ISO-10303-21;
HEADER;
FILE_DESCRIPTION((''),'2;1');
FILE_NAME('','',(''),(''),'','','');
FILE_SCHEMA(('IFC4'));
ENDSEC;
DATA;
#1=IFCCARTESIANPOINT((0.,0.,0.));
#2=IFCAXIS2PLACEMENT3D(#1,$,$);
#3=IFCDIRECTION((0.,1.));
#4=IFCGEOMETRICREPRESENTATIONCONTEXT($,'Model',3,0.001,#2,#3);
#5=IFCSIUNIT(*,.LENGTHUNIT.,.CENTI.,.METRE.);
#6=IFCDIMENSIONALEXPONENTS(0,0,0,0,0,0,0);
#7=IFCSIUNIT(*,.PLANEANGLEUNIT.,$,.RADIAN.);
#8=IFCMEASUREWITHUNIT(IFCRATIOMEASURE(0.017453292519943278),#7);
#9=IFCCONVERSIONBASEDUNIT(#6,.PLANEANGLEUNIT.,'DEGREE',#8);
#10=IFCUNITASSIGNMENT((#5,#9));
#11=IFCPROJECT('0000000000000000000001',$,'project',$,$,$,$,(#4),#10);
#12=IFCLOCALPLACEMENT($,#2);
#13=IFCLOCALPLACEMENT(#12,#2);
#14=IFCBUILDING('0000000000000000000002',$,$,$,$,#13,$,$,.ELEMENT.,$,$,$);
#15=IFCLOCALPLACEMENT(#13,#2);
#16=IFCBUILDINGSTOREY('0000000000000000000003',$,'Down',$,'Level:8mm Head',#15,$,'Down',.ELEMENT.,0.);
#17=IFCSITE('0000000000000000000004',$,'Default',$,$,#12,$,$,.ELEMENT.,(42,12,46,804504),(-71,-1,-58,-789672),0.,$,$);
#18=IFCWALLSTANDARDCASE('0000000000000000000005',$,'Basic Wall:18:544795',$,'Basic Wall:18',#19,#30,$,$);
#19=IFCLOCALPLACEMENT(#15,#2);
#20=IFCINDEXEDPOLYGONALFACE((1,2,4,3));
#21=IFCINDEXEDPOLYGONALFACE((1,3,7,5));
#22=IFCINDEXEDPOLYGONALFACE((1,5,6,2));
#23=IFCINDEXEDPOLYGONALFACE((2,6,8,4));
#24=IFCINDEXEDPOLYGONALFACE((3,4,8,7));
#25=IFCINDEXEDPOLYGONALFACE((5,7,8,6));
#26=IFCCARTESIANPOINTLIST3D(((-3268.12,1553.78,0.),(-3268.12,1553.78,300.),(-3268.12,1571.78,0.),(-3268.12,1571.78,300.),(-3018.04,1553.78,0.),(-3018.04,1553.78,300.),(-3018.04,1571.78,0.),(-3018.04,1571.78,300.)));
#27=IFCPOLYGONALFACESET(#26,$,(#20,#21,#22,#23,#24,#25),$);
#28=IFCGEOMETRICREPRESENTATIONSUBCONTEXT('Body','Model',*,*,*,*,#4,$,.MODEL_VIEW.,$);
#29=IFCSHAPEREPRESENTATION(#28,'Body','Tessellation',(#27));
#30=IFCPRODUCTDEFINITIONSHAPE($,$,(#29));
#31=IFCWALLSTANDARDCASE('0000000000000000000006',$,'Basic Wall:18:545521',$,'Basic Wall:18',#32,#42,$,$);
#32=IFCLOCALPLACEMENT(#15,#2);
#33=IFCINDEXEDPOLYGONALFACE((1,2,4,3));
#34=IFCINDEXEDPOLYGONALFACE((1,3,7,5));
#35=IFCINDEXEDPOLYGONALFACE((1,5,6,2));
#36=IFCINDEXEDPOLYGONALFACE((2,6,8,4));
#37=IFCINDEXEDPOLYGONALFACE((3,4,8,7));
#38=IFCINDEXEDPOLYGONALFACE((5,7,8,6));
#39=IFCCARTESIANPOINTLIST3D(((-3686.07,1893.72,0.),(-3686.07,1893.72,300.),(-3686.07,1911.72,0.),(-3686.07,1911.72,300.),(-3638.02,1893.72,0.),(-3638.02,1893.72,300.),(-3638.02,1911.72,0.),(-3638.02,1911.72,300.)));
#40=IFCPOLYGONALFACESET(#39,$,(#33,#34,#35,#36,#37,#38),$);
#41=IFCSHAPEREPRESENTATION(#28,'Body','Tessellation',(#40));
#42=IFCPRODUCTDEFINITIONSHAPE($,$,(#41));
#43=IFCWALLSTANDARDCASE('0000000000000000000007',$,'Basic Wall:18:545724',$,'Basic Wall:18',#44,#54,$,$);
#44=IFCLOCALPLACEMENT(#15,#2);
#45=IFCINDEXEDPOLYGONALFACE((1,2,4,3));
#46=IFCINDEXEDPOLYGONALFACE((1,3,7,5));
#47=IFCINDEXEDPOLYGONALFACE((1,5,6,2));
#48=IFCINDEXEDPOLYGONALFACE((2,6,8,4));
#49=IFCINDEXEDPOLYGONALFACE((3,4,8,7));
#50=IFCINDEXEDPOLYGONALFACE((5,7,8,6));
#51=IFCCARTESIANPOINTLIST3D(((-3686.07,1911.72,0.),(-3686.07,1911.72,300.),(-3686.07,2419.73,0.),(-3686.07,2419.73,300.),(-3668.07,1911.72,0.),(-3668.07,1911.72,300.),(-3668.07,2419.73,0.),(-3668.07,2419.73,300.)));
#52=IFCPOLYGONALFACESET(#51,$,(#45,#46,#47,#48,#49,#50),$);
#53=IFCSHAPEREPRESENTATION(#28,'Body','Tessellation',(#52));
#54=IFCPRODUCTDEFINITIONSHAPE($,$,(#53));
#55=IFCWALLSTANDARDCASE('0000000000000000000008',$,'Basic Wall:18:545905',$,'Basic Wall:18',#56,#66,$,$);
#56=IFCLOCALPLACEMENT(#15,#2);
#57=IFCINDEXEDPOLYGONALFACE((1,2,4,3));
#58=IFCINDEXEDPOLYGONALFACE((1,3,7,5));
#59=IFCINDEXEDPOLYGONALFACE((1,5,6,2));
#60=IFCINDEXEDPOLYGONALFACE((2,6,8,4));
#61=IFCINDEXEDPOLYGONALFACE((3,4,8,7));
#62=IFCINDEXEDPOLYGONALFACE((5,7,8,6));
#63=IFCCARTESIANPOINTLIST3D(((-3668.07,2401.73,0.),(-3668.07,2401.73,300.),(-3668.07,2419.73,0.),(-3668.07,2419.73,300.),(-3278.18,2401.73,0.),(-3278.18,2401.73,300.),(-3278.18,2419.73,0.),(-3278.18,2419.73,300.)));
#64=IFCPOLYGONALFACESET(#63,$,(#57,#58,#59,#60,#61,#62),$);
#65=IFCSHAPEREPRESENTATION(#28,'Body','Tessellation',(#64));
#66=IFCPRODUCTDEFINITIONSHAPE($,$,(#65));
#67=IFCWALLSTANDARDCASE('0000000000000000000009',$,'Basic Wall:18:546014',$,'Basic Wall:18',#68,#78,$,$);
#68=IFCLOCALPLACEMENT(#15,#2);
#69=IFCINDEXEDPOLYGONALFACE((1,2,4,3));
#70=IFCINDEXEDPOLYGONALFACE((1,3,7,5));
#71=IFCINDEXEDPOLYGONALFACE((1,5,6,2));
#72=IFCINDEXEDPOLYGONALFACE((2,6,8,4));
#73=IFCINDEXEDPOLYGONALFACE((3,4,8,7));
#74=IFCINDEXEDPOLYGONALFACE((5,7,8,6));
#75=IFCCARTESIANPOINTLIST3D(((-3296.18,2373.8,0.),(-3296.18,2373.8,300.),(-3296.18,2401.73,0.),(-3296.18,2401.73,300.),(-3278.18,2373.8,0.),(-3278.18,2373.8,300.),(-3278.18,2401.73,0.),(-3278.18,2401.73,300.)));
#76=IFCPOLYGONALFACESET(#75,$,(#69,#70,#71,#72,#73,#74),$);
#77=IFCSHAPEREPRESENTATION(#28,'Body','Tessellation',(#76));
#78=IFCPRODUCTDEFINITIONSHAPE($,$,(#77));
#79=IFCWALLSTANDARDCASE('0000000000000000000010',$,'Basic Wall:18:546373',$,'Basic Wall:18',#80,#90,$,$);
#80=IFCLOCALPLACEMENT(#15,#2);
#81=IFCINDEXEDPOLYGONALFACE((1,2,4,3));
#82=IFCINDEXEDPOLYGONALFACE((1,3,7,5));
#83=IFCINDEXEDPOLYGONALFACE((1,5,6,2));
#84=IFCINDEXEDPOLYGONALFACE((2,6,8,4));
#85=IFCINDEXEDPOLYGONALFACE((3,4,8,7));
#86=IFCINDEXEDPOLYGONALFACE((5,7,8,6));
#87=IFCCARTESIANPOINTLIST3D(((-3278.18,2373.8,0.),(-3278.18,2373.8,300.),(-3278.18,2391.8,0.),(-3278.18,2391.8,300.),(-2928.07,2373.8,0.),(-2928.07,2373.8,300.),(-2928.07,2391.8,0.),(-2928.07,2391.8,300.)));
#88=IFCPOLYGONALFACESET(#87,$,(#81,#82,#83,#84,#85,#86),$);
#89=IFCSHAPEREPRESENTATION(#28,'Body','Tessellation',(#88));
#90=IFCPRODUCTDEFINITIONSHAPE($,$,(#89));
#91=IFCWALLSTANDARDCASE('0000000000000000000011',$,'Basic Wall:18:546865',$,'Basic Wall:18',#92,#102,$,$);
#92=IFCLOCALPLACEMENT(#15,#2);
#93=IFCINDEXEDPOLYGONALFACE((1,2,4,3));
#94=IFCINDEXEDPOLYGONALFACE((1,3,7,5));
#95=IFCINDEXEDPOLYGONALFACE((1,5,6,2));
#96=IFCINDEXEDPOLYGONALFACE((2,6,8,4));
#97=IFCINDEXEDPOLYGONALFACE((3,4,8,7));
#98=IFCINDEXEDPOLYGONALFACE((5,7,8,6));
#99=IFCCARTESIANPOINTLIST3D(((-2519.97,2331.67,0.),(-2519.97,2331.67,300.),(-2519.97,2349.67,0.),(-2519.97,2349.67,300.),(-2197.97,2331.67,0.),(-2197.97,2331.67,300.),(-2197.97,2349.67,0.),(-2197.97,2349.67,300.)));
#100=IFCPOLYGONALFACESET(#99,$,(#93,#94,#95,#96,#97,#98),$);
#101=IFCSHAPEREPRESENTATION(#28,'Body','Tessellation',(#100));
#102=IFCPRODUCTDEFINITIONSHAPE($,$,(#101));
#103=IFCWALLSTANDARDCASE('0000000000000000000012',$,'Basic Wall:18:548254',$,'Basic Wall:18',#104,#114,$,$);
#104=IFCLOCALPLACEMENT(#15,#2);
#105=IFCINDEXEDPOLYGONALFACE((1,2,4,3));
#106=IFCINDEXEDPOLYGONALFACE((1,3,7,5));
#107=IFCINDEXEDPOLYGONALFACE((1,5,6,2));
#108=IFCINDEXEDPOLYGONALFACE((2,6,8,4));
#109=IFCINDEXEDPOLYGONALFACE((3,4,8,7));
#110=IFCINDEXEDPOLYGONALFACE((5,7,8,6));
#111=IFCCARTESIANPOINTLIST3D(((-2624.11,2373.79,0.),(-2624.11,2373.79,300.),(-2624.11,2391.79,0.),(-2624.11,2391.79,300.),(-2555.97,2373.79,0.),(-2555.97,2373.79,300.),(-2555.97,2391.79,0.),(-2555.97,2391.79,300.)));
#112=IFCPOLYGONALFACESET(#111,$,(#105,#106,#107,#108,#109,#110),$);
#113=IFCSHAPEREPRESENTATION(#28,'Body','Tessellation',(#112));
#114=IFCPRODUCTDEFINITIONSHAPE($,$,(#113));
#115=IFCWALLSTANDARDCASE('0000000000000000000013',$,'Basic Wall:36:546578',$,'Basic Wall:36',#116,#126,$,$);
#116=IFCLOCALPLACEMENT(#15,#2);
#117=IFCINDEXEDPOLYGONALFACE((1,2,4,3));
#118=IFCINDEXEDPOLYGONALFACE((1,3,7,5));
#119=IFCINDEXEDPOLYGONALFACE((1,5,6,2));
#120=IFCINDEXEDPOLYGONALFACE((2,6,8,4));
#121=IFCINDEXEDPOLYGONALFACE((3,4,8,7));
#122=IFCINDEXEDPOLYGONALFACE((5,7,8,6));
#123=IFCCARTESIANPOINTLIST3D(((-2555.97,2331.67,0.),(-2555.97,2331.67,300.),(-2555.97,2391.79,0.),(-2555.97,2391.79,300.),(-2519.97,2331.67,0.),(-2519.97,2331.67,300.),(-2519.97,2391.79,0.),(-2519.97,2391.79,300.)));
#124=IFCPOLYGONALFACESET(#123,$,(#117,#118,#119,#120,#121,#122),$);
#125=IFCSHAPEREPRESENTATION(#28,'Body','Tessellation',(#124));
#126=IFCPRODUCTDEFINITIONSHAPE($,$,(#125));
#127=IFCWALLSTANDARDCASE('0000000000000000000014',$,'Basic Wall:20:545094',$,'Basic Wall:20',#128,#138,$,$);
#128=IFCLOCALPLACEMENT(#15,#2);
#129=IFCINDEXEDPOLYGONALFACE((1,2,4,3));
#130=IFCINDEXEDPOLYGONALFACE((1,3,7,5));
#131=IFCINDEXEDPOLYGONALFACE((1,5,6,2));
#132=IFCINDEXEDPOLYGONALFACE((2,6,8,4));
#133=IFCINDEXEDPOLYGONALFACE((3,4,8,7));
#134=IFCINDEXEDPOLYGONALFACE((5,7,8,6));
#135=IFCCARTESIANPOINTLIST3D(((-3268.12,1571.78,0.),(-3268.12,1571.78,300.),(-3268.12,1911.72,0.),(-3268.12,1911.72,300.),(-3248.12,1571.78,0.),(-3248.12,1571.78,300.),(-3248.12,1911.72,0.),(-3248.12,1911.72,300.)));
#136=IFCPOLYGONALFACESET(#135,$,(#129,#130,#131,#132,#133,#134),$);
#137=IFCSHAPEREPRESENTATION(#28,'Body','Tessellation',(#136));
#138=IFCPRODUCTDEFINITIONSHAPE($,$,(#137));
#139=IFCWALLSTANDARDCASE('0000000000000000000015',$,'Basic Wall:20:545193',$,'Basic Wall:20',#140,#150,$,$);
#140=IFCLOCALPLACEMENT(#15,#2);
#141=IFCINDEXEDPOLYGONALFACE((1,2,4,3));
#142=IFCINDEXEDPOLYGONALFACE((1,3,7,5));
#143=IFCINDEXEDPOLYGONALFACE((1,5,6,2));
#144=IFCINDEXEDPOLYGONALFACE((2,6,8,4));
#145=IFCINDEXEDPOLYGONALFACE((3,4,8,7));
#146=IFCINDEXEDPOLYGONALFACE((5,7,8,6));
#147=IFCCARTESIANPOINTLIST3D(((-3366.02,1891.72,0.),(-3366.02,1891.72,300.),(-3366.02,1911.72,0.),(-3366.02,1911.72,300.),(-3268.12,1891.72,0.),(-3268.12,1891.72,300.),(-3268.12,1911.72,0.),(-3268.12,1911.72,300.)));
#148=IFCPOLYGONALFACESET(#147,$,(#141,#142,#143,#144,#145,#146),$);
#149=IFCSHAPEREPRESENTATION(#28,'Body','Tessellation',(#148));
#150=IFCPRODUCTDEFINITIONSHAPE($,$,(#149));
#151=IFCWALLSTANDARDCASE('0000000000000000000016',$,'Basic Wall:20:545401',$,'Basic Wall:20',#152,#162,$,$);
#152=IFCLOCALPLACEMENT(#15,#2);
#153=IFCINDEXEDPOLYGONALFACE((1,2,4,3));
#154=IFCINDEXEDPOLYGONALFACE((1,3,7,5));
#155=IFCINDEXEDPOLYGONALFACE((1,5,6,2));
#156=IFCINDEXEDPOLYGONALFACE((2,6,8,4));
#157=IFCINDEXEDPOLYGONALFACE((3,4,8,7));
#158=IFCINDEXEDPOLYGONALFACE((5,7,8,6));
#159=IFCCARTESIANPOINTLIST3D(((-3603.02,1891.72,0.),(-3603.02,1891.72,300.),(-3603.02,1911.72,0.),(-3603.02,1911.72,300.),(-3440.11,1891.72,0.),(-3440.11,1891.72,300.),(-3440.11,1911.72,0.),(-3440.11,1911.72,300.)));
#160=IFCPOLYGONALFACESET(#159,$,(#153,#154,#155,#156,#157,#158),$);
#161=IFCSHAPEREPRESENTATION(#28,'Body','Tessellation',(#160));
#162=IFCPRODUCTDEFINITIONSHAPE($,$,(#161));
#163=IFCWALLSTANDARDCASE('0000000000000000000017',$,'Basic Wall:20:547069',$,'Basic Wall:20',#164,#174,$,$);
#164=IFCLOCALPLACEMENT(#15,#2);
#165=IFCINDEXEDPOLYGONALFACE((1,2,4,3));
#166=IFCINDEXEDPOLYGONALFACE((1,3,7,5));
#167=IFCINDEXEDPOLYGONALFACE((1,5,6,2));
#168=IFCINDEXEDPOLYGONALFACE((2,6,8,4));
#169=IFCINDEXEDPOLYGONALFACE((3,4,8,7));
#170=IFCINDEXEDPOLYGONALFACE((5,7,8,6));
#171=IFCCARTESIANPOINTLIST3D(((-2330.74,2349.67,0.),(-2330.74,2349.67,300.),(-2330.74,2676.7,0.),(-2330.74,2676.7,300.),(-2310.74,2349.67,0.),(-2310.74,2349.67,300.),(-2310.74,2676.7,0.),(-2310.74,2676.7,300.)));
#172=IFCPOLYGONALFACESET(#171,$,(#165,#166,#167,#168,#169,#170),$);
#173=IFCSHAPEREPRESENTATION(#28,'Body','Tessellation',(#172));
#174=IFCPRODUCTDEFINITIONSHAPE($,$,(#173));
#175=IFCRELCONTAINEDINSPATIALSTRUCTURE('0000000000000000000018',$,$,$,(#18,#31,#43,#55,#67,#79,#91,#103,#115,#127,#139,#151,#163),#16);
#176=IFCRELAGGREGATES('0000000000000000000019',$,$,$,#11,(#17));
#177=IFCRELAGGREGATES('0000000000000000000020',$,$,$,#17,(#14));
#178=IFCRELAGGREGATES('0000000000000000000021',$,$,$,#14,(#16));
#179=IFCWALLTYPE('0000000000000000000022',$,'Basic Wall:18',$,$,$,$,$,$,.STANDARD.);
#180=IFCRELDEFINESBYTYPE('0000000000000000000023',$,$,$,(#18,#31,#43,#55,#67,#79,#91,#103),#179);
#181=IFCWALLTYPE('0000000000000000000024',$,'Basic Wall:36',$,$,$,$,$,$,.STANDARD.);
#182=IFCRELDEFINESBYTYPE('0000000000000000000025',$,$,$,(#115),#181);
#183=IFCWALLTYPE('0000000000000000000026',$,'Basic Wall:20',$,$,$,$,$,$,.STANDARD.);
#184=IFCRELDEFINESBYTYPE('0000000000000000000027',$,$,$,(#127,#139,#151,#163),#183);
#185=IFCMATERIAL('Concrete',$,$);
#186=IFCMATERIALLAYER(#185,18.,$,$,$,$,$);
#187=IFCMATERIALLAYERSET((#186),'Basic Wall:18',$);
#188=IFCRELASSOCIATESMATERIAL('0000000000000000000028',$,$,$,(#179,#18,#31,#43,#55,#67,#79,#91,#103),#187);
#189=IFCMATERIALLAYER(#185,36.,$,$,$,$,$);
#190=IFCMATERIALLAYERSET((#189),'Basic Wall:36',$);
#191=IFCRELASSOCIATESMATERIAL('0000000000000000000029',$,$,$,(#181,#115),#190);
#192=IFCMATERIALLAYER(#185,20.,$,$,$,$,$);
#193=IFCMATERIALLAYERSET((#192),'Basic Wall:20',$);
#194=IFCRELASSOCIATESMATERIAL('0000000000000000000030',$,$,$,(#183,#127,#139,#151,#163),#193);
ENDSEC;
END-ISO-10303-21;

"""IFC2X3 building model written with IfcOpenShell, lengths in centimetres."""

from ifc_helpers import new_model, entity, si_unit, converted_unit, direction, frame, frame_2d, origin, place, context, subcontext, project, spatial, rectangle, extrude, material, layer, layer_set, layer_usage, type_object, element, save


model = new_model("IFC2X3")

# Units and contexts
model_context = context("Model", 3, precision=0.001, world=origin(), true_north=direction((0.0, 1.0)))
body_context = subcontext(model_context, "Body", "Model", "MODEL_VIEW")
ifc_project = project(units=[si_unit("LENGTHUNIT", "METRE", prefix="CENTI"), converted_unit("PLANEANGLEUNIT", "DEGREE", entity("IfcRatioMeasure", 0.017453292519943278), si_unit("PLANEANGLEUNIT", "RADIAN"), dimensions=[0, 0, 0, 0, 0, 0, 0])], contexts=[model_context])

# Site, building, storey
site_placement = place(None, origin())
site = spatial("IfcSite", under=ifc_project, at=site_placement, Name="Default", CompositionType="ELEMENT", RefLatitude=(42, 12, 46, 804504), RefLongitude=(-71, -1, -58, -789672), RefElevation=0.0)
building_placement = place(site_placement, origin())
building = spatial("IfcBuilding", under=site, at=building_placement, CompositionType="ELEMENT")
storey_placement = place(building_placement, origin())
storey = spatial("IfcBuildingStorey", under=building, at=storey_placement, Name="Down", ObjectType="Level:8mm Head", LongName="Down", CompositionType="ELEMENT", Elevation=0.0)

# Walls
ifc_material = material(Name="Concrete")
ifc_layer_1 = layer(ifc_material, 18.0)
ifc_layer_set_1 = layer_set([ifc_layer_1], Name="Basic Wall:18")
ifc_layer_usage_1 = layer_usage(ifc_layer_set_1, "AXIS2", "POSITIVE", -9.0)
wall_type_1 = type_object("IfcWallType", Name="Basic Wall:18", PredefinedType="STANDARD", material=ifc_layer_set_1)
wall_1_placement = place(storey_placement, frame((-3018.04, 1562.78, 0.0), z_axis=(0.0, 0.0, 1.0), x_axis=(-1.0, 0.0, 0.0)))
element("IfcWallStandardCase", 1, at=wall_1_placement, inside=storey, type_object=wall_type_1, material=ifc_layer_usage_1, Name="Basic Wall:18:544795", ObjectType="Basic Wall:18", context=body_context, shape_type="SweptSolid", body=[
    extrude(rectangle(XDim=250.08, YDim=18.0, at=frame_2d((125.04, 0.0), x_axis=(-1.0, 0.0))), origin(), (0.0, 0.0, 1.0), 300.0),
])
ifc_layer_usage_2 = layer_usage(ifc_layer_set_1, "AXIS2", "POSITIVE", -9.0)
wall_2_placement = place(storey_placement, frame((-3638.02, 1902.72, 0.0), z_axis=(0.0, 0.0, 1.0), x_axis=(-1.0, 0.0, 0.0)))
element("IfcWallStandardCase", 2, at=wall_2_placement, inside=storey, type_object=wall_type_1, material=ifc_layer_usage_2, Name="Basic Wall:18:545521", ObjectType="Basic Wall:18", context=body_context, shape_type="SweptSolid", body=[
    extrude(rectangle(XDim=48.05, YDim=18.0, at=frame_2d((24.02, 0.0), x_axis=(-1.0, 0.0))), origin(), (0.0, 0.0, 1.0), 300.0),
])
ifc_layer_usage_3 = layer_usage(ifc_layer_set_1, "AXIS2", "NEGATIVE", 9.0)
wall_3_placement = place(storey_placement, frame((-3677.07, 1911.72, 0.0), z_axis=(0.0, 0.0, 1.0), x_axis=(0.0, 1.0, 0.0)))
element("IfcWallStandardCase", 3, at=wall_3_placement, inside=storey, type_object=wall_type_1, material=ifc_layer_usage_3, Name="Basic Wall:18:545724", ObjectType="Basic Wall:18", context=body_context, shape_type="SweptSolid", body=[
    extrude(rectangle(XDim=508.01, YDim=18.0, at=frame_2d((254.01, 0.0), x_axis=(-1.0, 0.0))), origin(), (0.0, 0.0, 1.0), 300.0),
])
ifc_layer_usage_4 = layer_usage(ifc_layer_set_1, "AXIS2", "NEGATIVE", 9.0)
wall_4_placement = place(storey_placement, frame((-3668.07, 2410.73, 0.0)))
element("IfcWallStandardCase", 4, at=wall_4_placement, inside=storey, type_object=wall_type_1, material=ifc_layer_usage_4, Name="Basic Wall:18:545905", ObjectType="Basic Wall:18", context=body_context, shape_type="SweptSolid", body=[
    extrude(rectangle(XDim=389.89, YDim=18.0, at=frame_2d((194.95, 0.0), x_axis=(-1.0, 0.0))), origin(), (0.0, 0.0, 1.0), 300.0),
])
ifc_layer_usage_5 = layer_usage(ifc_layer_set_1, "AXIS2", "NEGATIVE", 9.0)
wall_5_placement = place(storey_placement, frame((-3287.18, 2401.73, 0.0), z_axis=(0.0, 0.0, 1.0), x_axis=(0.0, -1.0, 0.0)))
element("IfcWallStandardCase", 5, at=wall_5_placement, inside=storey, type_object=wall_type_1, material=ifc_layer_usage_5, Name="Basic Wall:18:546014", ObjectType="Basic Wall:18", context=body_context, shape_type="SweptSolid", body=[
    extrude(rectangle(XDim=27.93, YDim=18.0, at=frame_2d((13.97, 0.0), x_axis=(-1.0, 0.0))), origin(), (0.0, 0.0, 1.0), 300.0),
])
ifc_layer_usage_6 = layer_usage(ifc_layer_set_1, "AXIS2", "POSITIVE", -9.0)
wall_6_placement = place(storey_placement, frame((-3278.18, 2382.8, 0.0)))
element("IfcWallStandardCase", 6, at=wall_6_placement, inside=storey, type_object=wall_type_1, material=ifc_layer_usage_6, Name="Basic Wall:18:546373", ObjectType="Basic Wall:18", context=body_context, shape_type="SweptSolid", body=[
    extrude(rectangle(XDim=350.1, YDim=18.0, at=frame_2d((175.05, 0.0), x_axis=(-1.0, 0.0))), origin(), (0.0, 0.0, 1.0), 300.0),
])
ifc_layer_usage_7 = layer_usage(ifc_layer_set_1, "AXIS2", "POSITIVE", -9.0)
wall_7_placement = place(storey_placement, frame((-2519.97, 2340.67, 0.0)))
element("IfcWallStandardCase", 7, at=wall_7_placement, inside=storey, type_object=wall_type_1, material=ifc_layer_usage_7, Name="Basic Wall:18:546865", ObjectType="Basic Wall:18", context=body_context, shape_type="SweptSolid", body=[
    extrude(rectangle(XDim=322.0, YDim=18.0, at=frame_2d((161.0, 0.0), x_axis=(-1.0, 0.0))), origin(), (0.0, 0.0, 1.0), 300.0),
])
ifc_layer_usage_8 = layer_usage(ifc_layer_set_1, "AXIS2", "POSITIVE", -9.0)
wall_8_placement = place(storey_placement, frame((-2555.97, 2382.79, 0.0), z_axis=(0.0, 0.0, 1.0), x_axis=(-1.0, 0.0, 0.0)))
element("IfcWallStandardCase", 8, at=wall_8_placement, inside=storey, type_object=wall_type_1, material=ifc_layer_usage_8, Name="Basic Wall:18:548254", ObjectType="Basic Wall:18", context=body_context, shape_type="SweptSolid", body=[
    extrude(rectangle(XDim=68.14, YDim=18.0, at=frame_2d((34.07, 0.0), x_axis=(-1.0, 0.0))), origin(), (0.0, 0.0, 1.0), 300.0),
])
ifc_layer_2 = layer(ifc_material, 36.0)
ifc_layer_set_2 = layer_set([ifc_layer_2], Name="Basic Wall:36")
ifc_layer_usage_9 = layer_usage(ifc_layer_set_2, "AXIS2", "NEGATIVE", 18.0)
wall_type_2 = type_object("IfcWallType", Name="Basic Wall:36", PredefinedType="STANDARD", material=ifc_layer_set_2)
wall_9_placement = place(storey_placement, frame((-2537.97, 2391.79, 0.0), z_axis=(0.0, 0.0, 1.0), x_axis=(0.0, -1.0, 0.0)))
element("IfcWallStandardCase", 9, at=wall_9_placement, inside=storey, type_object=wall_type_2, material=ifc_layer_usage_9, Name="Basic Wall:36:546578", ObjectType="Basic Wall:36", context=body_context, shape_type="SweptSolid", body=[
    extrude(rectangle(XDim=60.11, YDim=36.0, at=frame_2d((30.06, 0.0), x_axis=(-1.0, 0.0))), origin(), (0.0, 0.0, 1.0), 300.0),
])
ifc_layer_3 = layer(ifc_material, 20.0)
ifc_layer_set_3 = layer_set([ifc_layer_3], Name="Basic Wall:20")
ifc_layer_usage_10 = layer_usage(ifc_layer_set_3, "AXIS2", "POSITIVE", -10.0)
wall_type_3 = type_object("IfcWallType", Name="Basic Wall:20", PredefinedType="STANDARD", material=ifc_layer_set_3)
wall_10_placement = place(storey_placement, frame((-3258.12, 1571.78, 0.0), z_axis=(0.0, 0.0, 1.0), x_axis=(0.0, 1.0, 0.0)))
element("IfcWallStandardCase", 10, at=wall_10_placement, inside=storey, type_object=wall_type_3, material=ifc_layer_usage_10, Name="Basic Wall:20:545094", ObjectType="Basic Wall:20", context=body_context, shape_type="SweptSolid", body=[
    extrude(rectangle(XDim=339.94, YDim=20.0, at=frame_2d((169.97, 0.0), x_axis=(-1.0, 0.0))), origin(), (0.0, 0.0, 1.0), 300.0),
])
ifc_layer_usage_11 = layer_usage(ifc_layer_set_3, "AXIS2", "POSITIVE", -10.0)
wall_11_placement = place(storey_placement, frame((-3268.12, 1901.72, 0.0), z_axis=(0.0, 0.0, 1.0), x_axis=(-1.0, 0.0, 0.0)))
element("IfcWallStandardCase", 11, at=wall_11_placement, inside=storey, type_object=wall_type_3, material=ifc_layer_usage_11, Name="Basic Wall:20:545193", ObjectType="Basic Wall:20", context=body_context, shape_type="SweptSolid", body=[
    extrude(rectangle(XDim=97.9, YDim=20.0, at=frame_2d((48.95, 0.0), x_axis=(-1.0, 0.0))), origin(), (0.0, 0.0, 1.0), 300.0),
])
ifc_layer_usage_12 = layer_usage(ifc_layer_set_3, "AXIS2", "POSITIVE", -10.0)
wall_12_placement = place(storey_placement, frame((-3440.11, 1901.72, 0.0), z_axis=(0.0, 0.0, 1.0), x_axis=(-1.0, 0.0, 0.0)))
element("IfcWallStandardCase", 12, at=wall_12_placement, inside=storey, type_object=wall_type_3, material=ifc_layer_usage_12, Name="Basic Wall:20:545401", ObjectType="Basic Wall:20", context=body_context, shape_type="SweptSolid", body=[
    extrude(rectangle(XDim=162.91, YDim=20.0, at=frame_2d((81.46, 0.0), x_axis=(-1.0, 0.0))), origin(), (0.0, 0.0, 1.0), 300.0),
])
ifc_layer_usage_13 = layer_usage(ifc_layer_set_3, "AXIS2", "NEGATIVE", 10.0)
wall_13_placement = place(storey_placement, frame((-2320.74, 2349.67, 0.0), z_axis=(0.0, 0.0, 1.0), x_axis=(0.0, 1.0, 0.0)))
element("IfcWallStandardCase", 13, at=wall_13_placement, inside=storey, type_object=wall_type_3, material=ifc_layer_usage_13, Name="Basic Wall:20:547069", ObjectType="Basic Wall:20", context=body_context, shape_type="SweptSolid", body=[
    extrude(rectangle(XDim=327.02, YDim=20.0, at=frame_2d((163.51, 0.0), x_axis=(-1.0, 0.0))), origin(), (0.0, 0.0, 1.0), 300.0),
])

save(model, "model.ifc")
